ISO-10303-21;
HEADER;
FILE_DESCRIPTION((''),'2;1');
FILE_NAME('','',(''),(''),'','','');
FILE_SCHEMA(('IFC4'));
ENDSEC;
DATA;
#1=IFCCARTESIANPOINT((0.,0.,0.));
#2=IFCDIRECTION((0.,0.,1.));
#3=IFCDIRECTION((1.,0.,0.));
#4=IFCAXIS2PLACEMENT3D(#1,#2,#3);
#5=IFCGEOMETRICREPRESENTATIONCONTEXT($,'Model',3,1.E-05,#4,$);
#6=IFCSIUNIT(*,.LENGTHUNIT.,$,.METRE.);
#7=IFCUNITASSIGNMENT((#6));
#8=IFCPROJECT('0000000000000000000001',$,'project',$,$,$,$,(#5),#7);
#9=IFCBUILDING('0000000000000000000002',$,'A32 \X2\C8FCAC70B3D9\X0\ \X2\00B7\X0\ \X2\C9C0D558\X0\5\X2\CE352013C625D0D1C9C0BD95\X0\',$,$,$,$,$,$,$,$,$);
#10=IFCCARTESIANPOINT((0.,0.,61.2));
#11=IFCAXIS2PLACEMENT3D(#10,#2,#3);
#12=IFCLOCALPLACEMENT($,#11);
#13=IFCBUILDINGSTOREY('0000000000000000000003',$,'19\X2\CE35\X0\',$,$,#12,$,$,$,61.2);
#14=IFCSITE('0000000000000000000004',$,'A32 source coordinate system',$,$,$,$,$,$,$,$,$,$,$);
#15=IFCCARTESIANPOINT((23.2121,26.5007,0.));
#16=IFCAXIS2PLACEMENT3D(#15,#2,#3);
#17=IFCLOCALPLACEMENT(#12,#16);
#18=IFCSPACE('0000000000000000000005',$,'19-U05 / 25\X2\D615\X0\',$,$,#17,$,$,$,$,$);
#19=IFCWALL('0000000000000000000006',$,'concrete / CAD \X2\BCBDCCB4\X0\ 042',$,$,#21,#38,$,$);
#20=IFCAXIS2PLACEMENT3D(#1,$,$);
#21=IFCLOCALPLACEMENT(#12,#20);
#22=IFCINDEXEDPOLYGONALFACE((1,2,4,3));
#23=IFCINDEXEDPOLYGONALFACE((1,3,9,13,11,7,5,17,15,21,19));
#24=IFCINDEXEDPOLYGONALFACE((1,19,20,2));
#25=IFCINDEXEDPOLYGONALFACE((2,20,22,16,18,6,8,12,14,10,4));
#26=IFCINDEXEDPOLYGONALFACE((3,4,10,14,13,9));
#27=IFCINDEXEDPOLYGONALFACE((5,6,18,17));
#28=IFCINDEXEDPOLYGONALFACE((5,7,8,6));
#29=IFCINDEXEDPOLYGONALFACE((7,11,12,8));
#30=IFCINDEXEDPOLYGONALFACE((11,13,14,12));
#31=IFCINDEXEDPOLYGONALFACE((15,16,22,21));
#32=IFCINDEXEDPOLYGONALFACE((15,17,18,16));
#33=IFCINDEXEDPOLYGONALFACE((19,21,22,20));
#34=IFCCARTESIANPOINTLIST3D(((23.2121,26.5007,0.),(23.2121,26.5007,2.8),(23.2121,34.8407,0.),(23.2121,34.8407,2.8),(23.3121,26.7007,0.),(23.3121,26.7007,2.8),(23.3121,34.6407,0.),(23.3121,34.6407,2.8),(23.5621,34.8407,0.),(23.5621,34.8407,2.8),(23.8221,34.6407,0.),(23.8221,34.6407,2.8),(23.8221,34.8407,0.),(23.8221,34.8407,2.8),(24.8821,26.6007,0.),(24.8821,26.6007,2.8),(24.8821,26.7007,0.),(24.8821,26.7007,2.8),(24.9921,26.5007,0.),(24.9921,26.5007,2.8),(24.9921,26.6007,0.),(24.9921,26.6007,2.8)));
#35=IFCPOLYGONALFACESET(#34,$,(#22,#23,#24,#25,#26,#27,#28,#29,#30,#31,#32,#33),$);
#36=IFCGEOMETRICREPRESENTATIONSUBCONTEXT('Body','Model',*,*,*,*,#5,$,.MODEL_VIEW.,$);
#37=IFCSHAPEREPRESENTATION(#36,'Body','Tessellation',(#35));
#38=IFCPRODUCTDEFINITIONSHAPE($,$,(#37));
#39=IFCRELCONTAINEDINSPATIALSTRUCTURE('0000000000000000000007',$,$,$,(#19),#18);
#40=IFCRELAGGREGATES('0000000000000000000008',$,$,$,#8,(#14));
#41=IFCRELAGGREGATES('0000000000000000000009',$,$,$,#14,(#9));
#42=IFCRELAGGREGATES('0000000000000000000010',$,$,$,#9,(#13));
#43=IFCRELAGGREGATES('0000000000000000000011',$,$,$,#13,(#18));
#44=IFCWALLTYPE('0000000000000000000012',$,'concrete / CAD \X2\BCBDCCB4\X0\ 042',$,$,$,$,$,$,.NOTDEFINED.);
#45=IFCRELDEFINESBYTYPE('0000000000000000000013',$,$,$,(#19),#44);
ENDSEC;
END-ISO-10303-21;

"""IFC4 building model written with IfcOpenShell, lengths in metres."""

from ifc_helpers import new_model, si_unit, frame, origin, origin_with_axes, place, context, subcontext, project, spatial, polyline, outline, extrude, source, transform, mapped, type_object, type_shapes, element, save


model = new_model("IFC4")

# Units and contexts
model_context = context("Model", 3, precision=1e-05, world=origin_with_axes())
body_context = subcontext(model_context, "Body", "Model", "MODEL_VIEW")
ifc_project = project(units=[si_unit("LENGTHUNIT", "METRE")], contexts=[model_context])

# Site, building, storey, space
site = spatial("IfcSite", under=ifc_project, Name="A32 source coordinate system")
building = spatial("IfcBuilding", under=site, Name="A32 주거동 · 지하5층–옥탑지붕")
storey_placement = place(None, frame((0.0, 0.0, 61.2), z_axis=(0.0, 0.0, 1.0), x_axis=(1.0, 0.0, 0.0)))
storey = spatial("IfcBuildingStorey", under=building, at=storey_placement, Name="19층", Elevation=61.2)
space_1_placement = place(storey_placement, frame((23.2121, 26.5007, 0.0), z_axis=(0.0, 0.0, 1.0), x_axis=(1.0, 0.0, 0.0)))
space_1 = spatial("IfcSpace", under=storey, at=space_1_placement, Name="19-U05 / 25형")

# Wall
wall_type_1 = type_object("IfcWallType", Name="concrete / CAD 벽체 042", PredefinedType="NOTDEFINED")
shared_shape_1 = source(origin(), body_context, "Body", "SweptSolid", [
    extrude(outline(polyline([(0.1, 8.14), (0.1, 0.2), (1.67, 0.2), (1.67, 0.1), (1.78, 0.1), (1.78, 0.0), (0.0, 0.0), (0.0, 8.34), (0.35, 8.34), (0.35, 8.34), (0.61, 8.34), (0.61, 8.14), (0.1, 8.14)])), origin(), (0.0, 0.0, 1.0), 2.8),
])
type_shapes(wall_type_1, [shared_shape_1])
wall_1_placement = place(space_1_placement, origin_with_axes())
element("IfcWall", 1, at=wall_1_placement, inside=space_1, type_object=wall_type_1, Name="concrete / CAD 벽체 042", context=body_context, shape_type="MappedRepresentation", body=[
    mapped(shared_shape_1, transform((0.0, 0.0, 0.0), scale=1.0)),
])

save(model, "model.ifc")
